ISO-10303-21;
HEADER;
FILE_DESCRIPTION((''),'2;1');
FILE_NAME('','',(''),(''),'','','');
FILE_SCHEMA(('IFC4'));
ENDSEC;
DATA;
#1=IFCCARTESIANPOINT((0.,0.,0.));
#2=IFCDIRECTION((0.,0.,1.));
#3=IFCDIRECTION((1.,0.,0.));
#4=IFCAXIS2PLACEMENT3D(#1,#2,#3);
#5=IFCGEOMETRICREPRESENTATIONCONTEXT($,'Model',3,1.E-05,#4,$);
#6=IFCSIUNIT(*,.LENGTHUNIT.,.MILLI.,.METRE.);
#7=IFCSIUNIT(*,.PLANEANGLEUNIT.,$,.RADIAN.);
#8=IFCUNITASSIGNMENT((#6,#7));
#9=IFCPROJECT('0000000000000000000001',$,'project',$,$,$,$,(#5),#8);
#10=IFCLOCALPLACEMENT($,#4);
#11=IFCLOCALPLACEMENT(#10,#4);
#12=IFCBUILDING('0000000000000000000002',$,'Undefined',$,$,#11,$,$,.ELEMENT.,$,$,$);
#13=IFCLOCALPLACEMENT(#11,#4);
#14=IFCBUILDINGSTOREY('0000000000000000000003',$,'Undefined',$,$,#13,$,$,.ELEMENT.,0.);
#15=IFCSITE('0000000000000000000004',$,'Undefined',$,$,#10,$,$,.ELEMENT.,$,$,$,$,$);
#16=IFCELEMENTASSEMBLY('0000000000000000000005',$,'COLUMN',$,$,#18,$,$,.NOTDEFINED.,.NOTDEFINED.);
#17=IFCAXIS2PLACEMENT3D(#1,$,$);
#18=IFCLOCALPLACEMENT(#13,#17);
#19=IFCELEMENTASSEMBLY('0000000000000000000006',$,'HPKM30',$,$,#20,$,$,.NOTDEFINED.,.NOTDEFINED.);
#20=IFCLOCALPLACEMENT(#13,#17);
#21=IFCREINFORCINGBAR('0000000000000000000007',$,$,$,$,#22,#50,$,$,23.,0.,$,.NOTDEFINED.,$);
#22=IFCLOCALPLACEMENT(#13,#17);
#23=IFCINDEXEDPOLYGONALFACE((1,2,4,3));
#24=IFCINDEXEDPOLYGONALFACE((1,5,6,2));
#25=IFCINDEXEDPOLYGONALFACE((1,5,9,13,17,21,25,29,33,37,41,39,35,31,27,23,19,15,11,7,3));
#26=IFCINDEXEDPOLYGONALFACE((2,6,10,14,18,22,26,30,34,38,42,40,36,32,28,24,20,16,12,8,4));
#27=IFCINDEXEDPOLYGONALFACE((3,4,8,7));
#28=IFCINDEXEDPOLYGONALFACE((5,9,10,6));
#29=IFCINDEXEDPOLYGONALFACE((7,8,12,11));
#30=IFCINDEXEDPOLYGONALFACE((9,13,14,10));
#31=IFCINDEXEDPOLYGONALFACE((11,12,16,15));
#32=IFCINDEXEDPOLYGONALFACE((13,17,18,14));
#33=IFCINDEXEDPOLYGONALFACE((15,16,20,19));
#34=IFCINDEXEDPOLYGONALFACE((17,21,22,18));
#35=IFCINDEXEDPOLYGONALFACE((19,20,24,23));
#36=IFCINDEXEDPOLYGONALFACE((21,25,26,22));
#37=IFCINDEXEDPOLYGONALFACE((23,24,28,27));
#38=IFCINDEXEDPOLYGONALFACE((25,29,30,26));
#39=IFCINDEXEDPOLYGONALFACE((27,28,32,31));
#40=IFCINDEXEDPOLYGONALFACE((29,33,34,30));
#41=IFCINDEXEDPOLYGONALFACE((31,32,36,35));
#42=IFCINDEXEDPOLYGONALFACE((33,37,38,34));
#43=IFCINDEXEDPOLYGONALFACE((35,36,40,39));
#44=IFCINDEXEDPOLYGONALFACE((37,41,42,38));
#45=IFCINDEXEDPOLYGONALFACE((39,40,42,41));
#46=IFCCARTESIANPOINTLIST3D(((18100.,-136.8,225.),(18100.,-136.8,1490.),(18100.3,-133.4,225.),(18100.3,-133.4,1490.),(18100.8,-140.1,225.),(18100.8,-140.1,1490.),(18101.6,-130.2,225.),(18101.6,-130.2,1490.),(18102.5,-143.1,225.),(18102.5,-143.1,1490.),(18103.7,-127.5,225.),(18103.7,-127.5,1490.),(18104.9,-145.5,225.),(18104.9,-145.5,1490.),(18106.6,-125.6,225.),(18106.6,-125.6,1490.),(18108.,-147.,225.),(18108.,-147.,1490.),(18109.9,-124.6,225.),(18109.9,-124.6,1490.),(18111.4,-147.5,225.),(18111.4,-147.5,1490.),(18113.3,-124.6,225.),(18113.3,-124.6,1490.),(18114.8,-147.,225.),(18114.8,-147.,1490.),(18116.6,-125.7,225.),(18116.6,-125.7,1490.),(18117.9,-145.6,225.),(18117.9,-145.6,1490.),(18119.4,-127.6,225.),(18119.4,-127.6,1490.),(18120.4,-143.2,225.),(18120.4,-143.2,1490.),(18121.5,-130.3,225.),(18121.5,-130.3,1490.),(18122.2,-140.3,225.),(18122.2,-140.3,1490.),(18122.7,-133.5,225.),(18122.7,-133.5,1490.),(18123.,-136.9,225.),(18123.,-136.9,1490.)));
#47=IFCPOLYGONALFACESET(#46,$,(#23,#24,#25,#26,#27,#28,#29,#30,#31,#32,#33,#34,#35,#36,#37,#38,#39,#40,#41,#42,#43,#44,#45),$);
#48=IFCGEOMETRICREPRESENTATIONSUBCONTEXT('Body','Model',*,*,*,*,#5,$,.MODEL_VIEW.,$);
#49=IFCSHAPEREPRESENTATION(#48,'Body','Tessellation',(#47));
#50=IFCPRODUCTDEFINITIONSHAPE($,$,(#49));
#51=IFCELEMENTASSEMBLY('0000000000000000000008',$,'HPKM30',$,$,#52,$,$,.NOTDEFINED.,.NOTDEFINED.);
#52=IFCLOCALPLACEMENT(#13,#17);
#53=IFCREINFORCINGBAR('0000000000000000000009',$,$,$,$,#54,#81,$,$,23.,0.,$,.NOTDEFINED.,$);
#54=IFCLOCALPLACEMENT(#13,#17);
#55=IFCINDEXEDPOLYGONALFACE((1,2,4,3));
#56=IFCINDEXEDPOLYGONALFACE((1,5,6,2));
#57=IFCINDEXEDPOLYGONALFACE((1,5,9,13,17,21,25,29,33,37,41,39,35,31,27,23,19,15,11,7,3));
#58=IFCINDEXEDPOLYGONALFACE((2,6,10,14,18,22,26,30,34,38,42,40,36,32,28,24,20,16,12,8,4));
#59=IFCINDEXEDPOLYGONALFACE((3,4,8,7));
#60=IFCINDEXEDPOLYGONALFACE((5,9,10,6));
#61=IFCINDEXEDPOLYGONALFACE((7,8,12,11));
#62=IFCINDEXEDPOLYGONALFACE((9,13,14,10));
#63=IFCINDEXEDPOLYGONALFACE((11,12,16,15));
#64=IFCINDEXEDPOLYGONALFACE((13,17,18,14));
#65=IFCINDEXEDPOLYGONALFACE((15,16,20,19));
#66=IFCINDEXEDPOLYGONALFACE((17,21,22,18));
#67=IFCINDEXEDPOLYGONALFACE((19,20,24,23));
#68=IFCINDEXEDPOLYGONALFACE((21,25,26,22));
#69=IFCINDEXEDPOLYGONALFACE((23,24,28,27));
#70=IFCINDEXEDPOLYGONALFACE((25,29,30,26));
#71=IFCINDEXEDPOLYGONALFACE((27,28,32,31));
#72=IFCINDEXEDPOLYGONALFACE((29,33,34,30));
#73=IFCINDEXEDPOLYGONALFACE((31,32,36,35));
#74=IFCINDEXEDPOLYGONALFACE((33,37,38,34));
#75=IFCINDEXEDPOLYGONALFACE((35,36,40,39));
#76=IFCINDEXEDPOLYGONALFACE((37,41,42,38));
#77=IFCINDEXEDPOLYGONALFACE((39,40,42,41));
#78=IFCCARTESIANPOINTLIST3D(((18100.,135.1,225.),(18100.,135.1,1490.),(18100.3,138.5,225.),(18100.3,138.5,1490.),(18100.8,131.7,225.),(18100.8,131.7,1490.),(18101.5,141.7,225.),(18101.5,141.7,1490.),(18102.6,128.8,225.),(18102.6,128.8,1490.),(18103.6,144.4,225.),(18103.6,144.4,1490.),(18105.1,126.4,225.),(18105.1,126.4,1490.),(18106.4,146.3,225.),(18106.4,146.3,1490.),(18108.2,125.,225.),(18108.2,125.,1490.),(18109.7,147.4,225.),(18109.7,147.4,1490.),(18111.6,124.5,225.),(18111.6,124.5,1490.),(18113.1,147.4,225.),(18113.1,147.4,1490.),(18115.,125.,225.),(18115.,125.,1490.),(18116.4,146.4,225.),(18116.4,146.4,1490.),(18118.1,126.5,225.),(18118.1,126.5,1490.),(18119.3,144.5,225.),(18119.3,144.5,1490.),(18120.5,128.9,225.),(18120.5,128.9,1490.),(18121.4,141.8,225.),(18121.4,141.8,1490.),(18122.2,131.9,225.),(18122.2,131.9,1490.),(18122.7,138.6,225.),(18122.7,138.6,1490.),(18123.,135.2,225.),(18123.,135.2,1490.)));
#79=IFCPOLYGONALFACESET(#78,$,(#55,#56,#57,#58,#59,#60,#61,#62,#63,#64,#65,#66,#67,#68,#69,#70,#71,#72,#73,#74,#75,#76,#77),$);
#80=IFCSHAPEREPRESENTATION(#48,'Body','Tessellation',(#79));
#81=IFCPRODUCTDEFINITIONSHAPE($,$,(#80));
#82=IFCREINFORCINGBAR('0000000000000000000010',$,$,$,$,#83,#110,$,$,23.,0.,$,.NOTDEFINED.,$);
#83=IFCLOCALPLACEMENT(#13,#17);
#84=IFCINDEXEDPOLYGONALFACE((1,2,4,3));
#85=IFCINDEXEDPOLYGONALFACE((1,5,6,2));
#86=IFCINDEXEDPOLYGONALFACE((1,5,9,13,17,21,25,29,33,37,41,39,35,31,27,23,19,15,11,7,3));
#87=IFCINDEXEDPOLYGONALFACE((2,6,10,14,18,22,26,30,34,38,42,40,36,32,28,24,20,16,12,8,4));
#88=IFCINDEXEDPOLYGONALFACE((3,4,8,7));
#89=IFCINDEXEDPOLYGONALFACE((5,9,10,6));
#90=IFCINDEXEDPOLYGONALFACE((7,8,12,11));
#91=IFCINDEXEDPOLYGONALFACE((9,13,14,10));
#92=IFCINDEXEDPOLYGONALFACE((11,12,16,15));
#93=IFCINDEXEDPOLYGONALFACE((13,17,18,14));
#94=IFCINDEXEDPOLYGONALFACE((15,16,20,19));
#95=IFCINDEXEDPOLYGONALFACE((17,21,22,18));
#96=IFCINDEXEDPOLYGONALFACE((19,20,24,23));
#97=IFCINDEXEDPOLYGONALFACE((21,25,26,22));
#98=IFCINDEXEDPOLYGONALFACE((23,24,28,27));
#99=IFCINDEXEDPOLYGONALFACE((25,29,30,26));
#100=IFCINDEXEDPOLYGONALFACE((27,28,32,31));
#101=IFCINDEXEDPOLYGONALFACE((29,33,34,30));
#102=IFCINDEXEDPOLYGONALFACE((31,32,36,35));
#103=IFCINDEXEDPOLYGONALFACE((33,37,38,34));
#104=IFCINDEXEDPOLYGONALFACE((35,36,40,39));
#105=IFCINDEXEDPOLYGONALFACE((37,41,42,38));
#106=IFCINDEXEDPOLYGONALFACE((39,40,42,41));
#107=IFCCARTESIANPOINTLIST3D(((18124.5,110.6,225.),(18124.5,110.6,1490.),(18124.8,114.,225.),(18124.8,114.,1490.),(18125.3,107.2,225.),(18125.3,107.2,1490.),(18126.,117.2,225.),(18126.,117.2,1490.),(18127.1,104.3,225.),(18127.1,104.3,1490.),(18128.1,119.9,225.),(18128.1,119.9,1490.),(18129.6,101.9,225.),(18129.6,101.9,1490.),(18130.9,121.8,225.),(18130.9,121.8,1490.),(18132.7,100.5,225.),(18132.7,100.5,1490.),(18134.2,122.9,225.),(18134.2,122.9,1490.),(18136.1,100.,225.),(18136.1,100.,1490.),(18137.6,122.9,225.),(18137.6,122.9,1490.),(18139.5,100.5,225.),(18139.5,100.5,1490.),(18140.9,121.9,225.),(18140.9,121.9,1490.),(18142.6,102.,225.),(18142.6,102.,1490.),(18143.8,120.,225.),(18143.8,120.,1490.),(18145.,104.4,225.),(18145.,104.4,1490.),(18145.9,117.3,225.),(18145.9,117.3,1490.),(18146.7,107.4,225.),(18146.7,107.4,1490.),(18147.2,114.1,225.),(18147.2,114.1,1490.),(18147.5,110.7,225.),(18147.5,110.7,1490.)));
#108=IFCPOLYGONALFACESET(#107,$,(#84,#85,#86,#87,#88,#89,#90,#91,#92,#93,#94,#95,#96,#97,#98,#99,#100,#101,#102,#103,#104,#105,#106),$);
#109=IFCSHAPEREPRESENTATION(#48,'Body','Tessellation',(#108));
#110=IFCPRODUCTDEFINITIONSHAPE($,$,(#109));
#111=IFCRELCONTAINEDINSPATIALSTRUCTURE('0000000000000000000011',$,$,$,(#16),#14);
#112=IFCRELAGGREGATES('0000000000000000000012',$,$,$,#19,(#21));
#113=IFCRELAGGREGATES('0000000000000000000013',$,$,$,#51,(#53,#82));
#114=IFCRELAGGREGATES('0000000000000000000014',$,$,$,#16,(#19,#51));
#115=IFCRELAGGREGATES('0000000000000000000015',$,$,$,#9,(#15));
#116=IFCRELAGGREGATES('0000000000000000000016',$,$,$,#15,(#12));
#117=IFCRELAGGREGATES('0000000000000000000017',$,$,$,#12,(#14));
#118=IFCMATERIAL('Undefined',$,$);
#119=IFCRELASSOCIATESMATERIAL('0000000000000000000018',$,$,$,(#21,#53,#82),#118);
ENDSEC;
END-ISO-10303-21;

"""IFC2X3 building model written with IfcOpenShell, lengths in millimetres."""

from ifc_helpers import new_model, entity, si_unit, frame, origin_with_axes, place, context, subcontext, project, spatial, source, transform, mapped, material, element, aggregate, save


model = new_model("IFC2X3")

# Units and contexts
model_context = context("Model", 3, precision=1e-05, world=origin_with_axes())
body_context = subcontext(model_context, "Body", "Model", "MODEL_VIEW")
ifc_project = project(units=[si_unit("LENGTHUNIT", "METRE", prefix="MILLI"), si_unit("PLANEANGLEUNIT", "RADIAN")], contexts=[model_context])

# Site, building, storey
site_placement = place(None, origin_with_axes())
site = spatial("IfcSite", under=ifc_project, at=site_placement, Name="Undefined", CompositionType="ELEMENT")
building_placement = place(site_placement, origin_with_axes())
building = spatial("IfcBuilding", under=site, at=building_placement, Name="Undefined", CompositionType="ELEMENT")
storey_placement = place(building_placement, origin_with_axes())
storey = spatial("IfcBuildingStorey", under=building, at=storey_placement, Name="Undefined", CompositionType="ELEMENT", Elevation=0.0)

# Shared definitions
ifc_material_1 = material(Name="Undefined")

# Element assemblies, reinforcing bars
assembly_1_placement = place(storey_placement, origin_with_axes())
assembly_1 = element("IfcElementAssembly", 1, at=assembly_1_placement, inside=storey, Name="COLUMN", AssemblyPlace="NOTDEFINED", PredefinedType="NOTDEFINED")
assembly_2_placement = place(assembly_1_placement, origin_with_axes())
assembly_2 = element("IfcElementAssembly", 2, at=assembly_2_placement, Name="HPKM30", AssemblyPlace="NOTDEFINED", PredefinedType="NOTDEFINED")
shared_shape_1 = source(origin_with_axes(), body_context, "Body", "AdvancedSweptSolid", [
    entity("IfcSweptDiskSolid", entity("IfcTrimmedCurve", entity("IfcLine", entity("IfcCartesianPoint", [0.0, 0.0, 0.0]), entity("IfcVector", entity("IfcDirection", [1.0, 0.0, 0.0]), 1.0)), [entity("IfcParameterValue", 0.0)], [entity("IfcParameterValue", 1265.0)], True, "PARAMETER"), 11.5, None, 0.0, 1265.0),
])
reinforcing_bar_1_placement = place(assembly_2_placement, frame((18111.5, -136.0, 225.0), z_axis=(-0.007718, -0.99997, 0.0), x_axis=(0.0, 0.0, 1.0)))
reinforcing_bar_1 = element("IfcReinforcingBar", 3, at=reinforcing_bar_1_placement, material=ifc_material_1, BarRole="NOTDEFINED", CrossSectionArea=0.0, NominalDiameter=23.0, context=body_context, shape_type="MappedRepresentation", body=[
    mapped(shared_shape_1, transform((0.0, 0.0, 0.0))),
])
aggregate(assembly_2, [reinforcing_bar_1])
assembly_3_placement = place(assembly_1_placement, origin_with_axes())
assembly_3 = element("IfcElementAssembly", 4, at=assembly_3_placement, Name="HPKM30", AssemblyPlace="NOTDEFINED", PredefinedType="NOTDEFINED")
shared_shape_2 = source(origin_with_axes(), body_context, "Body", "AdvancedSweptSolid", [
    entity("IfcSweptDiskSolid", entity("IfcTrimmedCurve", entity("IfcLine", entity("IfcCartesianPoint", [0.0, 0.0, 0.0]), entity("IfcVector", entity("IfcDirection", [1.0, 0.0, 0.0]), 1.0)), [entity("IfcParameterValue", 0.0)], [entity("IfcParameterValue", 1265.0)], True, "PARAMETER"), 11.5, None, 0.0, 1265.0),
])
reinforcing_bar_2_placement = place(assembly_3_placement, frame((18111.5, 136.0, 225.0), z_axis=(0.007718, -0.99997, 0.0), x_axis=(0.0, 0.0, 1.0)))
reinforcing_bar_2 = element("IfcReinforcingBar", 5, at=reinforcing_bar_2_placement, material=ifc_material_1, BarRole="NOTDEFINED", CrossSectionArea=0.0, NominalDiameter=23.0, context=body_context, shape_type="MappedRepresentation", body=[
    mapped(shared_shape_2, transform((0.0, 0.0, 0.0))),
])
shared_shape_3 = source(origin_with_axes(), body_context, "Body", "AdvancedSweptSolid", [
    entity("IfcSweptDiskSolid", entity("IfcTrimmedCurve", entity("IfcLine", entity("IfcCartesianPoint", [0.0, 0.0, 0.0]), entity("IfcVector", entity("IfcDirection", [1.0, 0.0, 0.0]), 1.0)), [entity("IfcParameterValue", 0.0)], [entity("IfcParameterValue", 1265.0)], True, "PARAMETER"), 11.5, None, 0.0, 1265.0),
])
reinforcing_bar_3_placement = place(assembly_3_placement, frame((18136.0, 111.5, 225.0), z_axis=(0.007718, -0.99997, 0.0), x_axis=(0.0, 0.0, 1.0)))
reinforcing_bar_3 = element("IfcReinforcingBar", 6, at=reinforcing_bar_3_placement, material=ifc_material_1, BarRole="NOTDEFINED", CrossSectionArea=0.0, NominalDiameter=23.0, context=body_context, shape_type="MappedRepresentation", body=[
    mapped(shared_shape_3, transform((0.0, 0.0, 0.0))),
])
aggregate(assembly_3, [reinforcing_bar_2, reinforcing_bar_3])
aggregate(assembly_1, [assembly_2, assembly_3])

save(model, "model.ifc")
